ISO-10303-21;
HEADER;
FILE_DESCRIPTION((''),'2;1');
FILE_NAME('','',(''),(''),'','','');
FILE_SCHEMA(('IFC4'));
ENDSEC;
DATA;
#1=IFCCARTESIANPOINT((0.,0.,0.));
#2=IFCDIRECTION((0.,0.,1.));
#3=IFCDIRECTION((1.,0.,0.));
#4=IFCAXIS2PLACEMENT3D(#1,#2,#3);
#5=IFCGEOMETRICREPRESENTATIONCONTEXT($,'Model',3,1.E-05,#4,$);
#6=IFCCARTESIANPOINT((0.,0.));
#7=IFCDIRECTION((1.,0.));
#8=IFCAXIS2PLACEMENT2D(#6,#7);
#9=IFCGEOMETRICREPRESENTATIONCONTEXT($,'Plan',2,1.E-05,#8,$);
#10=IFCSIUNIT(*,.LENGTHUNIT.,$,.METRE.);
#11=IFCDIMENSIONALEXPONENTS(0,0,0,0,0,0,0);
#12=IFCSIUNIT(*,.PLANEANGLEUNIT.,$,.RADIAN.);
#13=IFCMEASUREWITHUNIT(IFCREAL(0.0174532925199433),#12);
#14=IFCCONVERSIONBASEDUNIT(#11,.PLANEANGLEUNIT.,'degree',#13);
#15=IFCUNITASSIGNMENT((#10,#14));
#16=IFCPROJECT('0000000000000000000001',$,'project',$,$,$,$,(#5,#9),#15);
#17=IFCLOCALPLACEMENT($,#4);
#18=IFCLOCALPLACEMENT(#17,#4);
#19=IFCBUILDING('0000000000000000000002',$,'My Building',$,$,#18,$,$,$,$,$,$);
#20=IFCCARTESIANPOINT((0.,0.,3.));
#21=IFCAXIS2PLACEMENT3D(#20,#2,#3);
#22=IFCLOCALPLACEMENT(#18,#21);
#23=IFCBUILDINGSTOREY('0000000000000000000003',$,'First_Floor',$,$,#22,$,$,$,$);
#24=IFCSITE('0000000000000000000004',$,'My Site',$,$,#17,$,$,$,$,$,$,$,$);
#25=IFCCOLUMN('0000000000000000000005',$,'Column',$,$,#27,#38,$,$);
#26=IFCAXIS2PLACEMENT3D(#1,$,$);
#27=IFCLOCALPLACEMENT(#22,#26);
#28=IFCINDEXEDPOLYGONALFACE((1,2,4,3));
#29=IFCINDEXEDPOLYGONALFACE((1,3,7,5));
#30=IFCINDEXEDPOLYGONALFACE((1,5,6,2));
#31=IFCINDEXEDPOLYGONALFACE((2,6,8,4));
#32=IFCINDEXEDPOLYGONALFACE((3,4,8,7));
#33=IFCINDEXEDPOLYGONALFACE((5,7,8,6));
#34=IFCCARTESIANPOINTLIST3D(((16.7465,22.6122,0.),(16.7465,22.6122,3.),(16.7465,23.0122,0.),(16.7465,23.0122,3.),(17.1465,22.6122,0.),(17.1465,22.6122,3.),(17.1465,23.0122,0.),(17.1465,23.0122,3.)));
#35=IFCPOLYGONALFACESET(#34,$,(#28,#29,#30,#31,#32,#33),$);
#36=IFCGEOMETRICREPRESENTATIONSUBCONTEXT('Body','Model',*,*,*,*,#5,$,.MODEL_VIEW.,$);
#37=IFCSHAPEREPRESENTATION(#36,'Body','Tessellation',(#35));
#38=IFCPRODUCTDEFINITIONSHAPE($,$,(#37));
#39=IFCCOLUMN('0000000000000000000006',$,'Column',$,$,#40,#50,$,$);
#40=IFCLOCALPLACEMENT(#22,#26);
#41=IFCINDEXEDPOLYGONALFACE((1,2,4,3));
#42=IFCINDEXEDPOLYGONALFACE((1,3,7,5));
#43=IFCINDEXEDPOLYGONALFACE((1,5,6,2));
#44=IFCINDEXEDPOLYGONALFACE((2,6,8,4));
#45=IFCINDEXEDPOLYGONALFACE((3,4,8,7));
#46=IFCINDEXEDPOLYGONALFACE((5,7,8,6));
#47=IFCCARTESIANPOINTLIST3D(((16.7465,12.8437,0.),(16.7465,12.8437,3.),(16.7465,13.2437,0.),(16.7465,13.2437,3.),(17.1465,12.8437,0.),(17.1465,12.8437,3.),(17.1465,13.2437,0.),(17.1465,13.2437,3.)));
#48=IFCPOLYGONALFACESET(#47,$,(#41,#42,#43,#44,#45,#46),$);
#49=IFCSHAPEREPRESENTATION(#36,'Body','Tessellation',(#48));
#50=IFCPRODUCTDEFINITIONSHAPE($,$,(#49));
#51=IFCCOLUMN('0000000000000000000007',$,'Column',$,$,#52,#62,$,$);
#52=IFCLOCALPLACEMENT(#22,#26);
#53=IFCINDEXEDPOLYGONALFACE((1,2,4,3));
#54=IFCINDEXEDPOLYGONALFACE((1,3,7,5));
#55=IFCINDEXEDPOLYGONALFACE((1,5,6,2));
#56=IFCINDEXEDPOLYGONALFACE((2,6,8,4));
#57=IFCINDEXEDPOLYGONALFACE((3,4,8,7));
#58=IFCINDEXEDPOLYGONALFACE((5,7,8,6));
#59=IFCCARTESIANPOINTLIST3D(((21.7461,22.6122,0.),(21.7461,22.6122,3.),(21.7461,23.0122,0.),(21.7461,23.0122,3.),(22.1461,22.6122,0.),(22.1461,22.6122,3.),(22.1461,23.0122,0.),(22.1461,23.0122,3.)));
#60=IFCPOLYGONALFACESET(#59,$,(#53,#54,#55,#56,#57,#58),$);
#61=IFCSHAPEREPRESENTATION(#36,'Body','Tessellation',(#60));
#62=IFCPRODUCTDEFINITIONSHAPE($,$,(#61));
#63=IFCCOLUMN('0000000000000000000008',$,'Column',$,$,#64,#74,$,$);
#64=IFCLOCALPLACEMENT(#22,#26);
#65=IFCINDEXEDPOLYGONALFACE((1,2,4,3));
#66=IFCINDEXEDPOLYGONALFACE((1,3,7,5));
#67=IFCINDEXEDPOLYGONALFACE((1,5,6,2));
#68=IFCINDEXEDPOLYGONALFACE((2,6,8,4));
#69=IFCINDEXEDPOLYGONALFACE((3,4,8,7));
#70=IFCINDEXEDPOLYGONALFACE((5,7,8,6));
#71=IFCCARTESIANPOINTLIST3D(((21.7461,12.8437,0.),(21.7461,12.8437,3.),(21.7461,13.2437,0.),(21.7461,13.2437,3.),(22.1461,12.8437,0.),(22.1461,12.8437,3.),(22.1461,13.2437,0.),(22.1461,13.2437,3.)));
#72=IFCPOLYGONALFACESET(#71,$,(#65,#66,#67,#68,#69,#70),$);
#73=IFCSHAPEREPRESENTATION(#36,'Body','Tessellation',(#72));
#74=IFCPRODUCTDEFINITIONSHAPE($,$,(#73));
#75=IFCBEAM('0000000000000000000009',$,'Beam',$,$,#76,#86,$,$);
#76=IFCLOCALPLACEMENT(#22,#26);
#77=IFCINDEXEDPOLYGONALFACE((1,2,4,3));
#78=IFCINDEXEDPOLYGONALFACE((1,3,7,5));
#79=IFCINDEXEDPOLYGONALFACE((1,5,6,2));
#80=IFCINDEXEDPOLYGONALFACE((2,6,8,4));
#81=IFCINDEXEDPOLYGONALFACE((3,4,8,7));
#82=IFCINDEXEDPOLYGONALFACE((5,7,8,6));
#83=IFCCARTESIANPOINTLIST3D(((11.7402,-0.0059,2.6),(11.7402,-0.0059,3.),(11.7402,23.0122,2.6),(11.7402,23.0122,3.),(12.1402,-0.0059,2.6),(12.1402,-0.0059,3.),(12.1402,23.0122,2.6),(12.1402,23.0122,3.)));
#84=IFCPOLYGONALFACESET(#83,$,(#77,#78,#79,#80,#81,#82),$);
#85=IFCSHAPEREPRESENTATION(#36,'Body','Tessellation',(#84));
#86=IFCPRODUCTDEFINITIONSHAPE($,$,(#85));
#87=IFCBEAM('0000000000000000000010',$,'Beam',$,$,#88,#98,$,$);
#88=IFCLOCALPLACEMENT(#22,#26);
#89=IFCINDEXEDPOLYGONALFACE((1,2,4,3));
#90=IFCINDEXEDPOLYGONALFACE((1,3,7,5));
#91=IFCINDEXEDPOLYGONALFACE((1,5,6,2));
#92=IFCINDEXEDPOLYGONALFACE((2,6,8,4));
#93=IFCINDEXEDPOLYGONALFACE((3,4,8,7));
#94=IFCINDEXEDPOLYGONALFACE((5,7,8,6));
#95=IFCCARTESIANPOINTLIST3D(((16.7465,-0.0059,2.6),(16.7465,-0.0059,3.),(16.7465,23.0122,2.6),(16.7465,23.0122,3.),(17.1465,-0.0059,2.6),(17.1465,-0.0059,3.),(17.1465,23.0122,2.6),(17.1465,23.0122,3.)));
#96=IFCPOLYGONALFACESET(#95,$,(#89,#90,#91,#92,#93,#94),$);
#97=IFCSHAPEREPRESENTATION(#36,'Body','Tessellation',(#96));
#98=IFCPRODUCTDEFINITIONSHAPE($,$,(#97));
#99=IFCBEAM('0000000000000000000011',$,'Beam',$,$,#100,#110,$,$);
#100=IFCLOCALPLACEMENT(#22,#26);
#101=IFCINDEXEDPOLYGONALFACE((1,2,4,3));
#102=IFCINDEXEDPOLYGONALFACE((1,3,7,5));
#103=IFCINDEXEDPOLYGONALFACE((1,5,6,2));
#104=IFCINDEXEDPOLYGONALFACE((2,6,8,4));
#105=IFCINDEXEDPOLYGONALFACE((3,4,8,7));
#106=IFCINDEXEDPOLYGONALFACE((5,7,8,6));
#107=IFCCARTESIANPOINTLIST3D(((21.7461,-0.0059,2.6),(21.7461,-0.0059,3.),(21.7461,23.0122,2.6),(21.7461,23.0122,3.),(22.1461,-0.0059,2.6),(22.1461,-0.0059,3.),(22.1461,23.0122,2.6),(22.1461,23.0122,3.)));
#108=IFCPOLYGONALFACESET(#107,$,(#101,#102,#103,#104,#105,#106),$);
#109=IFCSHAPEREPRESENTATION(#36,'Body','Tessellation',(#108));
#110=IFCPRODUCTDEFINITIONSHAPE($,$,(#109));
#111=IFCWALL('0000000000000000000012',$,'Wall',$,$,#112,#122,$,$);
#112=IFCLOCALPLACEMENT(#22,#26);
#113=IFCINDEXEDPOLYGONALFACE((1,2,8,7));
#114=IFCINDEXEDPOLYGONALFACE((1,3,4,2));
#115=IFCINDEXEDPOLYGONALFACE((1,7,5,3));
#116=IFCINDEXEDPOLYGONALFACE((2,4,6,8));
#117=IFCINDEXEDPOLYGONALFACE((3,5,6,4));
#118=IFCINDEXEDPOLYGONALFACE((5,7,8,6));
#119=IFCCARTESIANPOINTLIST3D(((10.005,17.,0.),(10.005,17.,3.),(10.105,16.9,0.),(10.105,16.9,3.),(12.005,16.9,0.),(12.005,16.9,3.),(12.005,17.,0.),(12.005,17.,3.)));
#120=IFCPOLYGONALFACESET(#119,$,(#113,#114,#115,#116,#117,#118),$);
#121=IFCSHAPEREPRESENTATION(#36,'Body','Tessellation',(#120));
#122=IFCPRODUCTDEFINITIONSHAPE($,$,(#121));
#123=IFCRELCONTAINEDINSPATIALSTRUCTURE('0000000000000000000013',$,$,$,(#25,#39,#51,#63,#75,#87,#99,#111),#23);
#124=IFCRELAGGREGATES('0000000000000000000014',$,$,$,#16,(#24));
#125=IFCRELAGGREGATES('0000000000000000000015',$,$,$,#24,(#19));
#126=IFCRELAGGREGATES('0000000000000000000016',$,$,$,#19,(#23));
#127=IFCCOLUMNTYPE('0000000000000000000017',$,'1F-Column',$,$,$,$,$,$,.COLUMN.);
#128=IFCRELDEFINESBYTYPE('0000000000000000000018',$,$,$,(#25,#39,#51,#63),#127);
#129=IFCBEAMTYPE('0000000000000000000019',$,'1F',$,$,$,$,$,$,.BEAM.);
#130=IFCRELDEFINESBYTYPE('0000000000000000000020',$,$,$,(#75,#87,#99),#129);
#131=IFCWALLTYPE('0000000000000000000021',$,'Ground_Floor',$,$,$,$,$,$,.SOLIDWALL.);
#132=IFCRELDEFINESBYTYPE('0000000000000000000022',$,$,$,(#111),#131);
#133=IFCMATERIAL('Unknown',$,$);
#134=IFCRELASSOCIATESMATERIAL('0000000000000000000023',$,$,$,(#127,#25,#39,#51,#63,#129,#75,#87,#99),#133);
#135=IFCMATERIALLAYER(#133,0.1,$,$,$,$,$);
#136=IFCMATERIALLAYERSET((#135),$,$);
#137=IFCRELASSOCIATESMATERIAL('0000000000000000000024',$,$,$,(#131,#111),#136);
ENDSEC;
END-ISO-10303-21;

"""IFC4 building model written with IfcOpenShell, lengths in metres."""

from ifc_helpers import new_model, entity, si_unit, converted_unit, frame, origin_with_axes, origin_2d_with_axis, place, context, subcontext, project, spatial, line, indexed_curve, rectangle, outline, extrude, material, layer, layer_set, layer_usage, material_profile, profile_set, profile_usage, type_object, element, save


model = new_model("IFC4")

# Units and contexts
model_context = context("Model", 3, precision=1e-05, world=origin_with_axes())
plan_context = context("Plan", 2, precision=1e-05, world=origin_2d_with_axis())
body_context_1 = subcontext(model_context, "Body", "Model", "MODEL_VIEW")
ifc_project = project(units=[si_unit("LENGTHUNIT", "METRE"), converted_unit("PLANEANGLEUNIT", "degree", entity("IfcReal", 0.0174532925199433), si_unit("PLANEANGLEUNIT", "RADIAN"), dimensions=[0, 0, 0, 0, 0, 0, 0])], contexts=[model_context, plan_context])

# Site, building, storey
site_placement = place(None, origin_with_axes())
site = spatial("IfcSite", under=ifc_project, at=site_placement, Name="My Site")
building_placement = place(site_placement, origin_with_axes())
building = spatial("IfcBuilding", under=site, at=building_placement, Name="My Building")
storey_placement = place(building_placement, frame((0.0, 0.0, 3.0), z_axis=(0.0, 0.0, 1.0), x_axis=(1.0, 0.0, 0.0)))
storey = spatial("IfcBuildingStorey", under=building, at=storey_placement, Name="First_Floor")

# Columns
ifc_material = material(Name="Unknown")
ifc_material_profile_1 = material_profile(ifc_material, rectangle(XDim=0.4, YDim=0.4))
ifc_profile_set_1 = profile_set([ifc_material_profile_1])
ifc_profile_usage_1 = profile_usage(ifc_profile_set_1, cardinal=5)
column_type = type_object("IfcColumnType", Name="1F-Column", PredefinedType="COLUMN", material=ifc_profile_set_1)
column_1_placement = place(storey_placement, frame((16.9465, 22.8122, 0.0), z_axis=(0.0, 0.0, 1.0), x_axis=(1.0, 0.0, 0.0)))
element("IfcColumn", 1, at=column_1_placement, inside=storey, type_object=column_type, material=ifc_profile_usage_1, Name="Column", context=body_context_1, shape_type="SweptSolid", body=[
    extrude(rectangle(XDim=0.4, YDim=0.4), origin_with_axes(), (0.0, 0.0, 1.0), 3.0),
])
ifc_profile_usage_2 = profile_usage(ifc_profile_set_1, cardinal=5)
column_2_placement = place(storey_placement, frame((16.9465, 13.0437, 0.0), z_axis=(0.0, 0.0, 1.0), x_axis=(1.0, 0.0, 0.0)))
element("IfcColumn", 2, at=column_2_placement, inside=storey, type_object=column_type, material=ifc_profile_usage_2, Name="Column", context=body_context_1, shape_type="SweptSolid", body=[
    extrude(rectangle(XDim=0.4, YDim=0.4), origin_with_axes(), (0.0, 0.0, 1.0), 3.0),
])
ifc_profile_usage_3 = profile_usage(ifc_profile_set_1, cardinal=5)
column_3_placement = place(storey_placement, frame((21.9461, 22.8122, 0.0), z_axis=(0.0, 0.0, 1.0), x_axis=(1.0, 0.0, 0.0)))
element("IfcColumn", 3, at=column_3_placement, inside=storey, type_object=column_type, material=ifc_profile_usage_3, Name="Column", context=body_context_1, shape_type="SweptSolid", body=[
    extrude(rectangle(XDim=0.4, YDim=0.4), origin_with_axes(), (0.0, 0.0, 1.0), 3.0),
])
ifc_profile_usage_4 = profile_usage(ifc_profile_set_1, cardinal=5)
column_4_placement = place(storey_placement, frame((21.9461, 13.0437, 0.0), z_axis=(0.0, 0.0, 1.0), x_axis=(1.0, 0.0, 0.0)))
element("IfcColumn", 4, at=column_4_placement, inside=storey, type_object=column_type, material=ifc_profile_usage_4, Name="Column", context=body_context_1, shape_type="SweptSolid", body=[
    extrude(rectangle(XDim=0.4, YDim=0.4), origin_with_axes(), (0.0, 0.0, 1.0), 3.0),
])

# Beams
ifc_material_profile_2 = material_profile(ifc_material, rectangle(XDim=0.4, YDim=0.4))
ifc_profile_set_2 = profile_set([ifc_material_profile_2])
ifc_profile_usage_5 = profile_usage(ifc_profile_set_2, cardinal=8)
beam_type = type_object("IfcBeamType", Name="1F", PredefinedType="BEAM", material=ifc_profile_set_2)
beam_1_placement = place(storey_placement, frame((11.9402, 23.0122, 3.0), z_axis=(0.0, -1.0, 0.0), x_axis=(1.0, 0.0, 0.0)))
element("IfcBeam", 5, at=beam_1_placement, inside=storey, type_object=beam_type, material=ifc_profile_usage_5, Name="Beam", context=body_context_1, shape_type="SweptSolid", body=[
    extrude(rectangle(XDim=0.4, YDim=0.4), frame((0.0, -0.2, 0.0), z_axis=(0.0, 0.0, 1.0), x_axis=(1.0, 0.0, 0.0)), (0.0, 0.0, 1.0), 23.0181),
])
ifc_profile_usage_6 = profile_usage(ifc_profile_set_2, cardinal=8)
beam_2_placement = place(storey_placement, frame((16.9465, 23.0122, 3.0), z_axis=(0.0, -1.0, 0.0), x_axis=(1.0, 0.0, 0.0)))
element("IfcBeam", 6, at=beam_2_placement, inside=storey, type_object=beam_type, material=ifc_profile_usage_6, Name="Beam", context=body_context_1, shape_type="SweptSolid", body=[
    extrude(rectangle(XDim=0.4, YDim=0.4), frame((0.0, -0.2, 0.0), z_axis=(0.0, 0.0, 1.0), x_axis=(1.0, 0.0, 0.0)), (0.0, 0.0, 1.0), 23.0181),
])
ifc_profile_usage_7 = profile_usage(ifc_profile_set_2, cardinal=8)
beam_3_placement = place(storey_placement, frame((21.9461, 23.0122, 3.0), z_axis=(0.0, -1.0, 0.0), x_axis=(1.0, 0.0, 0.0)))
element("IfcBeam", 7, at=beam_3_placement, inside=storey, type_object=beam_type, material=ifc_profile_usage_7, Name="Beam", context=body_context_1, shape_type="SweptSolid", body=[
    extrude(rectangle(XDim=0.4, YDim=0.4), frame((0.0, -0.2, 0.0), z_axis=(0.0, 0.0, 1.0), x_axis=(1.0, 0.0, 0.0)), (0.0, 0.0, 1.0), 23.0181),
])

# Wall
ifc_layer = layer(ifc_material, 0.1)
ifc_layer_set = layer_set([ifc_layer])
ifc_layer_usage_1 = layer_usage(ifc_layer_set, "AXIS2", "POSITIVE", 0.0)
wall_type = type_object("IfcWallType", Name="Ground_Floor", PredefinedType="SOLIDWALL", material=ifc_layer_set)
wall_1_placement = place(storey_placement, frame((12.005, 17.0, 0.0), z_axis=(0.0, 0.0, 1.0), x_axis=(-1.0, 0.0, 0.0)))
element("IfcWall", 8, at=wall_1_placement, inside=storey, type_object=wall_type, material=ifc_layer_usage_1, Name="Wall", context=body_context_1, shape_type="SweptSolid", body=[
    extrude(outline(indexed_curve([(0.0, 0.0), (0.0, 0.1), (1.9, 0.1), (2.0, 0.0)], segments=[line(1, 2, 3, 4, 1)])), origin_with_axes(), (0.0, 0.0, 1.0), 3.0),
])

save(model, "model.ifc")
